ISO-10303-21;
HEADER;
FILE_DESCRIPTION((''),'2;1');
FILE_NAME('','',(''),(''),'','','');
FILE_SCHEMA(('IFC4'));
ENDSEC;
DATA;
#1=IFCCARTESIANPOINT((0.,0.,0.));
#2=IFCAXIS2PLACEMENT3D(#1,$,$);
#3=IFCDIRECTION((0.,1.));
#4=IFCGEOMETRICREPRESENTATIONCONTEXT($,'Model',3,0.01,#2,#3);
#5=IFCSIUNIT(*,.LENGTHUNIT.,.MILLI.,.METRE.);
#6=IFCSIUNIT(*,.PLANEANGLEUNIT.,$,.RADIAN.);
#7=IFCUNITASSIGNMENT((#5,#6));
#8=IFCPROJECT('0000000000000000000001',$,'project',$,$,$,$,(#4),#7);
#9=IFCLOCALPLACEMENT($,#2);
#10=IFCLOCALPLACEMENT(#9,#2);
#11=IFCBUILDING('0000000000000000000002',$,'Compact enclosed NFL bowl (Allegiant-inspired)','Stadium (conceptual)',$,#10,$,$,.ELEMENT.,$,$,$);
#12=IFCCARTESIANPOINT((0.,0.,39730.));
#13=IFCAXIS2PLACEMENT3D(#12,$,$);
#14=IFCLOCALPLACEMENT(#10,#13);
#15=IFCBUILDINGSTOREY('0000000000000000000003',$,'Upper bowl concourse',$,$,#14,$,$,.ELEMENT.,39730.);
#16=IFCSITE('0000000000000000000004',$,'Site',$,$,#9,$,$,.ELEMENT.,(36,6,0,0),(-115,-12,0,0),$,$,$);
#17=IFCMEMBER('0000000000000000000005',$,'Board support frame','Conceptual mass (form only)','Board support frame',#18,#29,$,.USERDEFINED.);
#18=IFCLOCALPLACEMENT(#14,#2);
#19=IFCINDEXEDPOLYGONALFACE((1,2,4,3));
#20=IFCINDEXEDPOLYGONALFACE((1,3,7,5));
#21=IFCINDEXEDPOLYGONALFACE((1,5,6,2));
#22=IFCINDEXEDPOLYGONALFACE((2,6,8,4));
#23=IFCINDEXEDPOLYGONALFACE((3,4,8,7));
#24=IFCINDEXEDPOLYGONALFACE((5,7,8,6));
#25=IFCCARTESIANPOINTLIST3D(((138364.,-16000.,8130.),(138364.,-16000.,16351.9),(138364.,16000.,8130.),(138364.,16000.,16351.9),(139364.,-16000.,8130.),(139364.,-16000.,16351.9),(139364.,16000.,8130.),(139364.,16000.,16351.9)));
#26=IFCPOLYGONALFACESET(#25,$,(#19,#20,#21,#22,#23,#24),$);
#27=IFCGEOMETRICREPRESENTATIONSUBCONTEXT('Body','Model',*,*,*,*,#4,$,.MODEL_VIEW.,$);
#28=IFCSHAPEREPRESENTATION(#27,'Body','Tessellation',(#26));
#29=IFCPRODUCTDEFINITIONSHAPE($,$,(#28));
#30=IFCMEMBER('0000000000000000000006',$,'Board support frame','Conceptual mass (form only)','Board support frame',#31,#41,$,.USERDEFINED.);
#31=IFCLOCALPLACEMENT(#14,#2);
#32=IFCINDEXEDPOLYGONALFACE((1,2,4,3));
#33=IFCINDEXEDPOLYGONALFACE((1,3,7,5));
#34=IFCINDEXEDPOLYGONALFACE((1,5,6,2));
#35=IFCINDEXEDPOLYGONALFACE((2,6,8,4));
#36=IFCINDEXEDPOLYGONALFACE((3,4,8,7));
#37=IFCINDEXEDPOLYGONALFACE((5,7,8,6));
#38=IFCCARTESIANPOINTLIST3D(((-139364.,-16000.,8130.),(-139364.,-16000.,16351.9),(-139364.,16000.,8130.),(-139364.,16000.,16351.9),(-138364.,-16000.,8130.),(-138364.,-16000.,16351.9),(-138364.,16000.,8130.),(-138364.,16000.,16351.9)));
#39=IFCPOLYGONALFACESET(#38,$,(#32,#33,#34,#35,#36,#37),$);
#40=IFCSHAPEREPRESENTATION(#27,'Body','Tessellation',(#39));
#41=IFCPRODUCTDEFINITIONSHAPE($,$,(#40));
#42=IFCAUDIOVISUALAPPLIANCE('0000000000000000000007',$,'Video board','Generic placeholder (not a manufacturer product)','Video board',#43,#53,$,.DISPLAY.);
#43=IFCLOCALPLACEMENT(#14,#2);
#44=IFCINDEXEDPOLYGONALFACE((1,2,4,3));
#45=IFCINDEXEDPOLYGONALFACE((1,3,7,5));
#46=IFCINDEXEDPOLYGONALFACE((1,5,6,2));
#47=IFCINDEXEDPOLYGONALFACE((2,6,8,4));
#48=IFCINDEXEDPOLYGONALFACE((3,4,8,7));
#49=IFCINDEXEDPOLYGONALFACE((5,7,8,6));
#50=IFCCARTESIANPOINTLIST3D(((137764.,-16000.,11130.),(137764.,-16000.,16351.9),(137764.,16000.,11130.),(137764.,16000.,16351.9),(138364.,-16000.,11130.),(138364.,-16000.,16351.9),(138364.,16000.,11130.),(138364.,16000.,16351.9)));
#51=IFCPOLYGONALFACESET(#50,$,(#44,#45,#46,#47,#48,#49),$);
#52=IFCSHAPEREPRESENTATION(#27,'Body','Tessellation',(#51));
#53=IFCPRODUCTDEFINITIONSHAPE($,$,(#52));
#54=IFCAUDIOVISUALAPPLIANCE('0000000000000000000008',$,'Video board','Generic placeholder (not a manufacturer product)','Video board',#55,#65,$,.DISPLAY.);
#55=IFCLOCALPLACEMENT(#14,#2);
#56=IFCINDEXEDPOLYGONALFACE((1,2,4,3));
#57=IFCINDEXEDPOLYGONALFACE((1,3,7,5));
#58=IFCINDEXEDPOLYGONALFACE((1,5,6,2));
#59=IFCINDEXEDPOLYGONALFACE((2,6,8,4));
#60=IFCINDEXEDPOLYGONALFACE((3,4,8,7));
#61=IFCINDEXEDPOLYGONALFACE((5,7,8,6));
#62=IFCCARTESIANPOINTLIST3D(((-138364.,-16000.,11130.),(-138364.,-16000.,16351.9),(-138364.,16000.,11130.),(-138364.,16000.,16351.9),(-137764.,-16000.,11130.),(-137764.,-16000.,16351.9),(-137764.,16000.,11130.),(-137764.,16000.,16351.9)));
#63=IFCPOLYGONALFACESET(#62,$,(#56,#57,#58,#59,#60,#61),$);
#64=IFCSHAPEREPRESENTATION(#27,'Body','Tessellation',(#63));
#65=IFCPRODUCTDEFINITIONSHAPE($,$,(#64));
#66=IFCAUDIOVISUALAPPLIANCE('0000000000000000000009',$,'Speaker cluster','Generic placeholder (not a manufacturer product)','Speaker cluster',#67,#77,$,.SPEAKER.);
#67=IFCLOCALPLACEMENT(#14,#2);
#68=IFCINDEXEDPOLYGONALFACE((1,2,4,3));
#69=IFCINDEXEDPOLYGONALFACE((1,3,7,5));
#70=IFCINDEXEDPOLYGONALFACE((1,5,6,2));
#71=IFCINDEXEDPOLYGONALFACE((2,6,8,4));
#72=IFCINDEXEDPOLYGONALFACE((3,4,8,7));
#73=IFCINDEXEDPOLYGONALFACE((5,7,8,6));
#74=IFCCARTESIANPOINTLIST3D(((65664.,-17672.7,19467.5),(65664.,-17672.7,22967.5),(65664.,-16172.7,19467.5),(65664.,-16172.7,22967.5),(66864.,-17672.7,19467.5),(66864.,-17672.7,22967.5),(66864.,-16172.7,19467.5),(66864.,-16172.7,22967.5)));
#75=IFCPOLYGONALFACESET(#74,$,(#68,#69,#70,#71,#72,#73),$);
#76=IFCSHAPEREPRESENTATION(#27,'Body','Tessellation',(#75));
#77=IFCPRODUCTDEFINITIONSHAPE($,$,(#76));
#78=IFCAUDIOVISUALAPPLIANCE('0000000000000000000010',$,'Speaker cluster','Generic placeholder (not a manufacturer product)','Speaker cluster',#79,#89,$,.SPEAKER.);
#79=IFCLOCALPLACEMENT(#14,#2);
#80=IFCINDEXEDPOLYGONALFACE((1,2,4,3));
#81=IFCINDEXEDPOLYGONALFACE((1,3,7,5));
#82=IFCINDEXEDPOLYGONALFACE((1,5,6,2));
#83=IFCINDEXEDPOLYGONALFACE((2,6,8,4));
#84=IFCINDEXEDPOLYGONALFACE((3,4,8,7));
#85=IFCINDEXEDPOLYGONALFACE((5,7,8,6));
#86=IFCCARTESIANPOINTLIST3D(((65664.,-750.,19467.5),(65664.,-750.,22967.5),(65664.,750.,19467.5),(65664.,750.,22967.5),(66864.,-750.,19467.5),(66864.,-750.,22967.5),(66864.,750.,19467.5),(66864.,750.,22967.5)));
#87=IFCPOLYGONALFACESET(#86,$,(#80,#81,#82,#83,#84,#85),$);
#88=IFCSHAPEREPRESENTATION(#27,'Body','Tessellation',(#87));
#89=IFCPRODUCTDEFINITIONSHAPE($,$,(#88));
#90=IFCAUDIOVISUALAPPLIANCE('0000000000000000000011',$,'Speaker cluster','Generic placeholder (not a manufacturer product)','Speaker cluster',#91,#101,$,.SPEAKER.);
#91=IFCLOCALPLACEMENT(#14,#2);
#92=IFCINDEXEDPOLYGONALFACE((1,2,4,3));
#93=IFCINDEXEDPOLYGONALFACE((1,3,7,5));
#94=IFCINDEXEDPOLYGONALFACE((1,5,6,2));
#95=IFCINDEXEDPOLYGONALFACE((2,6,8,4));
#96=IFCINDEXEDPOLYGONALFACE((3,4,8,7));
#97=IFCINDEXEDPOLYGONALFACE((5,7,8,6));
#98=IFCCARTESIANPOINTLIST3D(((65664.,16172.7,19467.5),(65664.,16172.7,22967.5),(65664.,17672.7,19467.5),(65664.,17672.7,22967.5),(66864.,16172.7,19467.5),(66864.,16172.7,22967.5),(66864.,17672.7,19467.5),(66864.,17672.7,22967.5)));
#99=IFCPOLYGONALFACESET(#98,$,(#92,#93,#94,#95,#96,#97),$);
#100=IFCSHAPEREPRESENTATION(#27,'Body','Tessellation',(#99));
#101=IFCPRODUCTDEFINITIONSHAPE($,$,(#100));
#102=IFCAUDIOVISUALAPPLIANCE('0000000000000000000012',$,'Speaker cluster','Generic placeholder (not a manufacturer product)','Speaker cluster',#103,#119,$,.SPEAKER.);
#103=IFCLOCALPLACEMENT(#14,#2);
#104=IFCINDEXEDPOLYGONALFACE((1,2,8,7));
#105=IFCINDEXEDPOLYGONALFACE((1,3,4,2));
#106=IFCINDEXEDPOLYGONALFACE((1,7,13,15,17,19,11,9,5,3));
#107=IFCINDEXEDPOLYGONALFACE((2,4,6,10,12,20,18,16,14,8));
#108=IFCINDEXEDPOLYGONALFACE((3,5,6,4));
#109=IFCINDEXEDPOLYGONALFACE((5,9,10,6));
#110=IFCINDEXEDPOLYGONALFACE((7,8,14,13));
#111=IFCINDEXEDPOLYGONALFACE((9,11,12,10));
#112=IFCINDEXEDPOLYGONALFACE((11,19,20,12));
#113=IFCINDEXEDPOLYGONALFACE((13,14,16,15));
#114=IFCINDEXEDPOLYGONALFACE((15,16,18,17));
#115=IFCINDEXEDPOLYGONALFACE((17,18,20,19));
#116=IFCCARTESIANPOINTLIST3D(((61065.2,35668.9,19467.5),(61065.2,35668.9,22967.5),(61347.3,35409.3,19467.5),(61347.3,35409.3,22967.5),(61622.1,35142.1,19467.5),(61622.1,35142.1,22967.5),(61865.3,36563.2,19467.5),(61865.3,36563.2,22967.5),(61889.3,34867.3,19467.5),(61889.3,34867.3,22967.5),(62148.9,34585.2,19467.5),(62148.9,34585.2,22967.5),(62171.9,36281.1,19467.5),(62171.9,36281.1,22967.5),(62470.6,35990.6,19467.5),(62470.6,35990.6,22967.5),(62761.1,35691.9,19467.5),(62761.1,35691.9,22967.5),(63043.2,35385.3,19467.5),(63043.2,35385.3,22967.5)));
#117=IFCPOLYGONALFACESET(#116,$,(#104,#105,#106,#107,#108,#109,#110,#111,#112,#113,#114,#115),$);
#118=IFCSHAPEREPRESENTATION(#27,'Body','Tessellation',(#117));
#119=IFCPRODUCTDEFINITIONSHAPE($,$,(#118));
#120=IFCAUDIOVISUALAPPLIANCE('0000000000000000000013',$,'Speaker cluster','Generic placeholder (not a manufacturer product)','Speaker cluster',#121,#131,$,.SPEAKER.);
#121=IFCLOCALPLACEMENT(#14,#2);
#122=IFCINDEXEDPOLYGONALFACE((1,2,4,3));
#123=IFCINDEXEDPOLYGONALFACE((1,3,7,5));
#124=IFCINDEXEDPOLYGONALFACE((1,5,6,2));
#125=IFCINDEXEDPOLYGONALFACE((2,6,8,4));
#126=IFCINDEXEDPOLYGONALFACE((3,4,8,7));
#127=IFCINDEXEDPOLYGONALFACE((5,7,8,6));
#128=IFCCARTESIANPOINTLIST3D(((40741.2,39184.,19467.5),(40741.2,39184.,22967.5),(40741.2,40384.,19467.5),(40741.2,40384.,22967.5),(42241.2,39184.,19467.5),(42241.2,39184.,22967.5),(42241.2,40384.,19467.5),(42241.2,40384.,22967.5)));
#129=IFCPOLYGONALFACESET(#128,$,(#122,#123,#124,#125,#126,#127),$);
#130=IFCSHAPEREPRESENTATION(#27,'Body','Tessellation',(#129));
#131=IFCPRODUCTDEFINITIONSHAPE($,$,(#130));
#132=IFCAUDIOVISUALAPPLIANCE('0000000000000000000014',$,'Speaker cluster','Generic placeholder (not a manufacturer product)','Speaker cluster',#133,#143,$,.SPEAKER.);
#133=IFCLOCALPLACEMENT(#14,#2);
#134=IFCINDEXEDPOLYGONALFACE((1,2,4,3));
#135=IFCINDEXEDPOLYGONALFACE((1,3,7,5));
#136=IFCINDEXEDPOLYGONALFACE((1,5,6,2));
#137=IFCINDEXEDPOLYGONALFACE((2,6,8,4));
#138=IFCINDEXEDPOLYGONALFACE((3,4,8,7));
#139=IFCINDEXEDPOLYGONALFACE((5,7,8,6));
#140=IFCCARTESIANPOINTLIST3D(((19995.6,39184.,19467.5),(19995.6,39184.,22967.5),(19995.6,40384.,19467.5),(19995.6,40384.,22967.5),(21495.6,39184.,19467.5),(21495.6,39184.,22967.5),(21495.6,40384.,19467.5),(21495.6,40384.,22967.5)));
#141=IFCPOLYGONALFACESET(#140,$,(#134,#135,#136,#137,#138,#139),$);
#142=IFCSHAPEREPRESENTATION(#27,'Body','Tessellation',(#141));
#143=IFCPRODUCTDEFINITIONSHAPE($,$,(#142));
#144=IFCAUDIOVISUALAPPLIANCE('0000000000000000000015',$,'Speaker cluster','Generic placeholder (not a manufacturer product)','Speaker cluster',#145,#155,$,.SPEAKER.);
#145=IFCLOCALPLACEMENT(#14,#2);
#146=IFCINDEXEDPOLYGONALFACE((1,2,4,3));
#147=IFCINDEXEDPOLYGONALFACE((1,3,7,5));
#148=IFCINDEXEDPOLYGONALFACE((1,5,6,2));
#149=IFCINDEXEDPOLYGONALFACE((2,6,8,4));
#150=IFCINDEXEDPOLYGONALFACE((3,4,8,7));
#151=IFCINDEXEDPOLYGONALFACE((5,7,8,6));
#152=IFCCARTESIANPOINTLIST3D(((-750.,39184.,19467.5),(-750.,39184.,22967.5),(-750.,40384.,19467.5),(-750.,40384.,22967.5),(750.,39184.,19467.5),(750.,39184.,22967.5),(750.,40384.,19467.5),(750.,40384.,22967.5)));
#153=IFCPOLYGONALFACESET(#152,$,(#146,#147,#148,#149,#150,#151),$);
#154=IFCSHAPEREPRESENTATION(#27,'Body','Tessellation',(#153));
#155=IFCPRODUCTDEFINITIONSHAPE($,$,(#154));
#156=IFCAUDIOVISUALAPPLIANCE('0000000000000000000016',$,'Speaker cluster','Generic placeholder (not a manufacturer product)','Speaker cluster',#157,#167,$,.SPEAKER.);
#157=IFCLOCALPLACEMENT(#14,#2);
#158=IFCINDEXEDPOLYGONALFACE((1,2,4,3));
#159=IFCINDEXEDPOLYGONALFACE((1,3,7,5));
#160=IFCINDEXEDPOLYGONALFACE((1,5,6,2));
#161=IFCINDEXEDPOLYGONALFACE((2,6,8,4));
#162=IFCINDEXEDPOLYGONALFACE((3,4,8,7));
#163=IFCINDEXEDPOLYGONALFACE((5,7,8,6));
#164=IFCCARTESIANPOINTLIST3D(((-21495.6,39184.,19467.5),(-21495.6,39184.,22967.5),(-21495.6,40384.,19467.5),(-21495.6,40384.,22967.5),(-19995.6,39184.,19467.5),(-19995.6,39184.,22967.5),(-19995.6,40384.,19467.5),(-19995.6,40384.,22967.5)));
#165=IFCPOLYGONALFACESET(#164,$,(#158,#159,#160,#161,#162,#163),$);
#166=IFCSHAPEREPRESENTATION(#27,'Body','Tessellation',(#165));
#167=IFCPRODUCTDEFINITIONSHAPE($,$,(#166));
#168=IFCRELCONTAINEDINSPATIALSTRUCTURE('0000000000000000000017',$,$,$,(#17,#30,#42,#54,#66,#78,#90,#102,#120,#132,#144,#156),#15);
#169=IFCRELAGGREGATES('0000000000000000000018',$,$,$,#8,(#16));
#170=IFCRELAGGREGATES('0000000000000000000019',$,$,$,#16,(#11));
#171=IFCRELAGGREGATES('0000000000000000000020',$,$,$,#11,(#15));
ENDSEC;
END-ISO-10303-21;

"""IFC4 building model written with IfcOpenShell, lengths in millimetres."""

from ifc_helpers import new_model, si_unit, direction, frame, origin, place, context, subcontext, project, spatial, line, arc, indexed_curve, outline, extrude, element, save


model = new_model("IFC4")

# Units and contexts
model_context = context("Model", 3, precision=0.01, world=origin(), true_north=direction((0.0, 1.0)))
body_context = subcontext(model_context, "Body", "Model", "MODEL_VIEW")
ifc_project = project(units=[si_unit("LENGTHUNIT", "METRE", prefix="MILLI"), si_unit("PLANEANGLEUNIT", "RADIAN")], contexts=[model_context])

# Site, building, storey
site_placement = place(None, origin())
site = spatial("IfcSite", under=ifc_project, at=site_placement, Name="Site", CompositionType="ELEMENT", RefLatitude=(36, 6, 0, 0), RefLongitude=(-115, -12, 0, 0))
building_placement = place(site_placement, origin())
building = spatial("IfcBuilding", under=site, at=building_placement, Name="Compact enclosed NFL bowl (Allegiant-inspired)", Description="Stadium (conceptual)", CompositionType="ELEMENT")
storey_placement = place(building_placement, frame((0.0, 0.0, 39730.0)))
storey = spatial("IfcBuildingStorey", under=building, at=storey_placement, Name="Upper bowl concourse", CompositionType="ELEMENT", Elevation=39730.0)

# Shared definitions
placement = place(storey_placement, frame((0.0, 0.0, -39730.0)))

# Members
element("IfcMember", 1, at=placement, inside=storey, Name="Board support frame", Description="Conceptual mass (form only)", ObjectType="Board support frame", PredefinedType="USERDEFINED", context=body_context, shape_type="SweptSolid", body=[
    extrude(outline(indexed_curve([(138364.0, -16000.0), (138364.0, 16000.0), (139364.0, 16000.0), (139364.0, -16000.0)], segments=[line(1, 2), line(2, 3), line(3, 4), line(4, 1)], self_intersect=False)), frame((0.0, 0.0, 47860.0)), (0.0, 0.0, 1.0), 8221.9),
])
element("IfcMember", 2, at=placement, inside=storey, Name="Board support frame", Description="Conceptual mass (form only)", ObjectType="Board support frame", PredefinedType="USERDEFINED", context=body_context, shape_type="SweptSolid", body=[
    extrude(outline(indexed_curve([(-138364.0, 16000.0), (-138364.0, -16000.0), (-139364.0, -16000.0), (-139364.0, 16000.0)], segments=[line(1, 2), line(2, 3), line(3, 4), line(4, 1)], self_intersect=False)), frame((0.0, 0.0, 47860.0)), (0.0, 0.0, 1.0), 8221.9),
])

# Audio visual appliances
element("IfcAudioVisualAppliance", 3, at=placement, inside=storey, Name="Video board", Description="Generic placeholder (not a manufacturer product)", ObjectType="Video board", PredefinedType="DISPLAY", context=body_context, shape_type="SweptSolid", body=[
    extrude(outline(indexed_curve([(137764.0, -16000.0), (137764.0, 16000.0), (138364.0, 16000.0), (138364.0, -16000.0)], segments=[line(1, 2), line(2, 3), line(3, 4), line(4, 1)], self_intersect=False)), frame((0.0, 0.0, 50860.0)), (0.0, 0.0, 1.0), 5221.9),
])
element("IfcAudioVisualAppliance", 4, at=placement, inside=storey, Name="Video board", Description="Generic placeholder (not a manufacturer product)", ObjectType="Video board", PredefinedType="DISPLAY", context=body_context, shape_type="SweptSolid", body=[
    extrude(outline(indexed_curve([(-137764.0, 16000.0), (-137764.0, -16000.0), (-138364.0, -16000.0), (-138364.0, 16000.0)], segments=[line(1, 2), line(2, 3), line(3, 4), line(4, 1)], self_intersect=False)), frame((0.0, 0.0, 50860.0)), (0.0, 0.0, 1.0), 5221.9),
])
element("IfcAudioVisualAppliance", 5, at=placement, inside=storey, Name="Speaker cluster", Description="Generic placeholder (not a manufacturer product)", ObjectType="Speaker cluster", PredefinedType="SPEAKER", context=body_context, shape_type="SweptSolid", body=[
    extrude(outline(indexed_curve([(65664.0, -17672.7), (65664.0, -16172.7), (66864.0, -16172.7), (66864.0, -17672.7)], segments=[line(1, 2), line(2, 3), line(3, 4), line(4, 1)], self_intersect=False)), frame((0.0, 0.0, 59197.5)), (0.0, 0.0, 1.0), 3500.0),
])
element("IfcAudioVisualAppliance", 6, at=placement, inside=storey, Name="Speaker cluster", Description="Generic placeholder (not a manufacturer product)", ObjectType="Speaker cluster", PredefinedType="SPEAKER", context=body_context, shape_type="SweptSolid", body=[
    extrude(outline(indexed_curve([(65664.0, -750.0), (65664.0, 750.0), (66864.0, 750.0), (66864.0, -750.0)], segments=[line(1, 2), line(2, 3), line(3, 4), line(4, 1)], self_intersect=False)), frame((0.0, 0.0, 59197.5)), (0.0, 0.0, 1.0), 3500.0),
])
element("IfcAudioVisualAppliance", 7, at=placement, inside=storey, Name="Speaker cluster", Description="Generic placeholder (not a manufacturer product)", ObjectType="Speaker cluster", PredefinedType="SPEAKER", context=body_context, shape_type="SweptSolid", body=[
    extrude(outline(indexed_curve([(65664.0, 16172.7), (65664.0, 17672.7), (66864.0, 17672.7), (66864.0, 16172.7)], segments=[line(1, 2), line(2, 3), line(3, 4), line(4, 1)], self_intersect=False)), frame((0.0, 0.0, 59197.5)), (0.0, 0.0, 1.0), 3500.0),
])
element("IfcAudioVisualAppliance", 8, at=placement, inside=storey, Name="Speaker cluster", Description="Generic placeholder (not a manufacturer product)", ObjectType="Speaker cluster", PredefinedType="SPEAKER", context=body_context, shape_type="SweptSolid", body=[
    extrude(outline(indexed_curve([(62148.9, 34585.2), (61622.1, 35142.1), (61065.2, 35668.9), (61865.3, 36563.2), (62470.6, 35990.6), (63043.2, 35385.3)], segments=[arc(1, 2, 3), line(3, 4), arc(4, 5, 6), line(6, 1)], self_intersect=False)), frame((0.0, 0.0, 59197.5)), (0.0, 0.0, 1.0), 3500.0),
])
element("IfcAudioVisualAppliance", 9, at=placement, inside=storey, Name="Speaker cluster", Description="Generic placeholder (not a manufacturer product)", ObjectType="Speaker cluster", PredefinedType="SPEAKER", context=body_context, shape_type="SweptSolid", body=[
    extrude(outline(indexed_curve([(42241.2, 39184.0), (40741.2, 39184.0), (40741.2, 40384.0), (42241.2, 40384.0)], segments=[line(1, 2), line(2, 3), line(3, 4), line(4, 1)], self_intersect=False)), frame((0.0, 0.0, 59197.5)), (0.0, 0.0, 1.0), 3500.0),
])
element("IfcAudioVisualAppliance", 10, at=placement, inside=storey, Name="Speaker cluster", Description="Generic placeholder (not a manufacturer product)", ObjectType="Speaker cluster", PredefinedType="SPEAKER", context=body_context, shape_type="SweptSolid", body=[
    extrude(outline(indexed_curve([(21495.6, 39184.0), (19995.6, 39184.0), (19995.6, 40384.0), (21495.6, 40384.0)], segments=[line(1, 2), line(2, 3), line(3, 4), line(4, 1)], self_intersect=False)), frame((0.0, 0.0, 59197.5)), (0.0, 0.0, 1.0), 3500.0),
])
element("IfcAudioVisualAppliance", 11, at=placement, inside=storey, Name="Speaker cluster", Description="Generic placeholder (not a manufacturer product)", ObjectType="Speaker cluster", PredefinedType="SPEAKER", context=body_context, shape_type="SweptSolid", body=[
    extrude(outline(indexed_curve([(750.0, 39184.0), (-750.0, 39184.0), (-750.0, 40384.0), (750.0, 40384.0)], segments=[line(1, 2), line(2, 3), line(3, 4), line(4, 1)], self_intersect=False)), frame((0.0, 0.0, 59197.5)), (0.0, 0.0, 1.0), 3500.0),
])
element("IfcAudioVisualAppliance", 12, at=placement, inside=storey, Name="Speaker cluster", Description="Generic placeholder (not a manufacturer product)", ObjectType="Speaker cluster", PredefinedType="SPEAKER", context=body_context, shape_type="SweptSolid", body=[
    extrude(outline(indexed_curve([(-19995.6, 39184.0), (-21495.6, 39184.0), (-21495.6, 40384.0), (-19995.6, 40384.0)], segments=[line(1, 2), line(2, 3), line(3, 4), line(4, 1)], self_intersect=False)), frame((0.0, 0.0, 59197.5)), (0.0, 0.0, 1.0), 3500.0),
])

save(model, "model.ifc")
